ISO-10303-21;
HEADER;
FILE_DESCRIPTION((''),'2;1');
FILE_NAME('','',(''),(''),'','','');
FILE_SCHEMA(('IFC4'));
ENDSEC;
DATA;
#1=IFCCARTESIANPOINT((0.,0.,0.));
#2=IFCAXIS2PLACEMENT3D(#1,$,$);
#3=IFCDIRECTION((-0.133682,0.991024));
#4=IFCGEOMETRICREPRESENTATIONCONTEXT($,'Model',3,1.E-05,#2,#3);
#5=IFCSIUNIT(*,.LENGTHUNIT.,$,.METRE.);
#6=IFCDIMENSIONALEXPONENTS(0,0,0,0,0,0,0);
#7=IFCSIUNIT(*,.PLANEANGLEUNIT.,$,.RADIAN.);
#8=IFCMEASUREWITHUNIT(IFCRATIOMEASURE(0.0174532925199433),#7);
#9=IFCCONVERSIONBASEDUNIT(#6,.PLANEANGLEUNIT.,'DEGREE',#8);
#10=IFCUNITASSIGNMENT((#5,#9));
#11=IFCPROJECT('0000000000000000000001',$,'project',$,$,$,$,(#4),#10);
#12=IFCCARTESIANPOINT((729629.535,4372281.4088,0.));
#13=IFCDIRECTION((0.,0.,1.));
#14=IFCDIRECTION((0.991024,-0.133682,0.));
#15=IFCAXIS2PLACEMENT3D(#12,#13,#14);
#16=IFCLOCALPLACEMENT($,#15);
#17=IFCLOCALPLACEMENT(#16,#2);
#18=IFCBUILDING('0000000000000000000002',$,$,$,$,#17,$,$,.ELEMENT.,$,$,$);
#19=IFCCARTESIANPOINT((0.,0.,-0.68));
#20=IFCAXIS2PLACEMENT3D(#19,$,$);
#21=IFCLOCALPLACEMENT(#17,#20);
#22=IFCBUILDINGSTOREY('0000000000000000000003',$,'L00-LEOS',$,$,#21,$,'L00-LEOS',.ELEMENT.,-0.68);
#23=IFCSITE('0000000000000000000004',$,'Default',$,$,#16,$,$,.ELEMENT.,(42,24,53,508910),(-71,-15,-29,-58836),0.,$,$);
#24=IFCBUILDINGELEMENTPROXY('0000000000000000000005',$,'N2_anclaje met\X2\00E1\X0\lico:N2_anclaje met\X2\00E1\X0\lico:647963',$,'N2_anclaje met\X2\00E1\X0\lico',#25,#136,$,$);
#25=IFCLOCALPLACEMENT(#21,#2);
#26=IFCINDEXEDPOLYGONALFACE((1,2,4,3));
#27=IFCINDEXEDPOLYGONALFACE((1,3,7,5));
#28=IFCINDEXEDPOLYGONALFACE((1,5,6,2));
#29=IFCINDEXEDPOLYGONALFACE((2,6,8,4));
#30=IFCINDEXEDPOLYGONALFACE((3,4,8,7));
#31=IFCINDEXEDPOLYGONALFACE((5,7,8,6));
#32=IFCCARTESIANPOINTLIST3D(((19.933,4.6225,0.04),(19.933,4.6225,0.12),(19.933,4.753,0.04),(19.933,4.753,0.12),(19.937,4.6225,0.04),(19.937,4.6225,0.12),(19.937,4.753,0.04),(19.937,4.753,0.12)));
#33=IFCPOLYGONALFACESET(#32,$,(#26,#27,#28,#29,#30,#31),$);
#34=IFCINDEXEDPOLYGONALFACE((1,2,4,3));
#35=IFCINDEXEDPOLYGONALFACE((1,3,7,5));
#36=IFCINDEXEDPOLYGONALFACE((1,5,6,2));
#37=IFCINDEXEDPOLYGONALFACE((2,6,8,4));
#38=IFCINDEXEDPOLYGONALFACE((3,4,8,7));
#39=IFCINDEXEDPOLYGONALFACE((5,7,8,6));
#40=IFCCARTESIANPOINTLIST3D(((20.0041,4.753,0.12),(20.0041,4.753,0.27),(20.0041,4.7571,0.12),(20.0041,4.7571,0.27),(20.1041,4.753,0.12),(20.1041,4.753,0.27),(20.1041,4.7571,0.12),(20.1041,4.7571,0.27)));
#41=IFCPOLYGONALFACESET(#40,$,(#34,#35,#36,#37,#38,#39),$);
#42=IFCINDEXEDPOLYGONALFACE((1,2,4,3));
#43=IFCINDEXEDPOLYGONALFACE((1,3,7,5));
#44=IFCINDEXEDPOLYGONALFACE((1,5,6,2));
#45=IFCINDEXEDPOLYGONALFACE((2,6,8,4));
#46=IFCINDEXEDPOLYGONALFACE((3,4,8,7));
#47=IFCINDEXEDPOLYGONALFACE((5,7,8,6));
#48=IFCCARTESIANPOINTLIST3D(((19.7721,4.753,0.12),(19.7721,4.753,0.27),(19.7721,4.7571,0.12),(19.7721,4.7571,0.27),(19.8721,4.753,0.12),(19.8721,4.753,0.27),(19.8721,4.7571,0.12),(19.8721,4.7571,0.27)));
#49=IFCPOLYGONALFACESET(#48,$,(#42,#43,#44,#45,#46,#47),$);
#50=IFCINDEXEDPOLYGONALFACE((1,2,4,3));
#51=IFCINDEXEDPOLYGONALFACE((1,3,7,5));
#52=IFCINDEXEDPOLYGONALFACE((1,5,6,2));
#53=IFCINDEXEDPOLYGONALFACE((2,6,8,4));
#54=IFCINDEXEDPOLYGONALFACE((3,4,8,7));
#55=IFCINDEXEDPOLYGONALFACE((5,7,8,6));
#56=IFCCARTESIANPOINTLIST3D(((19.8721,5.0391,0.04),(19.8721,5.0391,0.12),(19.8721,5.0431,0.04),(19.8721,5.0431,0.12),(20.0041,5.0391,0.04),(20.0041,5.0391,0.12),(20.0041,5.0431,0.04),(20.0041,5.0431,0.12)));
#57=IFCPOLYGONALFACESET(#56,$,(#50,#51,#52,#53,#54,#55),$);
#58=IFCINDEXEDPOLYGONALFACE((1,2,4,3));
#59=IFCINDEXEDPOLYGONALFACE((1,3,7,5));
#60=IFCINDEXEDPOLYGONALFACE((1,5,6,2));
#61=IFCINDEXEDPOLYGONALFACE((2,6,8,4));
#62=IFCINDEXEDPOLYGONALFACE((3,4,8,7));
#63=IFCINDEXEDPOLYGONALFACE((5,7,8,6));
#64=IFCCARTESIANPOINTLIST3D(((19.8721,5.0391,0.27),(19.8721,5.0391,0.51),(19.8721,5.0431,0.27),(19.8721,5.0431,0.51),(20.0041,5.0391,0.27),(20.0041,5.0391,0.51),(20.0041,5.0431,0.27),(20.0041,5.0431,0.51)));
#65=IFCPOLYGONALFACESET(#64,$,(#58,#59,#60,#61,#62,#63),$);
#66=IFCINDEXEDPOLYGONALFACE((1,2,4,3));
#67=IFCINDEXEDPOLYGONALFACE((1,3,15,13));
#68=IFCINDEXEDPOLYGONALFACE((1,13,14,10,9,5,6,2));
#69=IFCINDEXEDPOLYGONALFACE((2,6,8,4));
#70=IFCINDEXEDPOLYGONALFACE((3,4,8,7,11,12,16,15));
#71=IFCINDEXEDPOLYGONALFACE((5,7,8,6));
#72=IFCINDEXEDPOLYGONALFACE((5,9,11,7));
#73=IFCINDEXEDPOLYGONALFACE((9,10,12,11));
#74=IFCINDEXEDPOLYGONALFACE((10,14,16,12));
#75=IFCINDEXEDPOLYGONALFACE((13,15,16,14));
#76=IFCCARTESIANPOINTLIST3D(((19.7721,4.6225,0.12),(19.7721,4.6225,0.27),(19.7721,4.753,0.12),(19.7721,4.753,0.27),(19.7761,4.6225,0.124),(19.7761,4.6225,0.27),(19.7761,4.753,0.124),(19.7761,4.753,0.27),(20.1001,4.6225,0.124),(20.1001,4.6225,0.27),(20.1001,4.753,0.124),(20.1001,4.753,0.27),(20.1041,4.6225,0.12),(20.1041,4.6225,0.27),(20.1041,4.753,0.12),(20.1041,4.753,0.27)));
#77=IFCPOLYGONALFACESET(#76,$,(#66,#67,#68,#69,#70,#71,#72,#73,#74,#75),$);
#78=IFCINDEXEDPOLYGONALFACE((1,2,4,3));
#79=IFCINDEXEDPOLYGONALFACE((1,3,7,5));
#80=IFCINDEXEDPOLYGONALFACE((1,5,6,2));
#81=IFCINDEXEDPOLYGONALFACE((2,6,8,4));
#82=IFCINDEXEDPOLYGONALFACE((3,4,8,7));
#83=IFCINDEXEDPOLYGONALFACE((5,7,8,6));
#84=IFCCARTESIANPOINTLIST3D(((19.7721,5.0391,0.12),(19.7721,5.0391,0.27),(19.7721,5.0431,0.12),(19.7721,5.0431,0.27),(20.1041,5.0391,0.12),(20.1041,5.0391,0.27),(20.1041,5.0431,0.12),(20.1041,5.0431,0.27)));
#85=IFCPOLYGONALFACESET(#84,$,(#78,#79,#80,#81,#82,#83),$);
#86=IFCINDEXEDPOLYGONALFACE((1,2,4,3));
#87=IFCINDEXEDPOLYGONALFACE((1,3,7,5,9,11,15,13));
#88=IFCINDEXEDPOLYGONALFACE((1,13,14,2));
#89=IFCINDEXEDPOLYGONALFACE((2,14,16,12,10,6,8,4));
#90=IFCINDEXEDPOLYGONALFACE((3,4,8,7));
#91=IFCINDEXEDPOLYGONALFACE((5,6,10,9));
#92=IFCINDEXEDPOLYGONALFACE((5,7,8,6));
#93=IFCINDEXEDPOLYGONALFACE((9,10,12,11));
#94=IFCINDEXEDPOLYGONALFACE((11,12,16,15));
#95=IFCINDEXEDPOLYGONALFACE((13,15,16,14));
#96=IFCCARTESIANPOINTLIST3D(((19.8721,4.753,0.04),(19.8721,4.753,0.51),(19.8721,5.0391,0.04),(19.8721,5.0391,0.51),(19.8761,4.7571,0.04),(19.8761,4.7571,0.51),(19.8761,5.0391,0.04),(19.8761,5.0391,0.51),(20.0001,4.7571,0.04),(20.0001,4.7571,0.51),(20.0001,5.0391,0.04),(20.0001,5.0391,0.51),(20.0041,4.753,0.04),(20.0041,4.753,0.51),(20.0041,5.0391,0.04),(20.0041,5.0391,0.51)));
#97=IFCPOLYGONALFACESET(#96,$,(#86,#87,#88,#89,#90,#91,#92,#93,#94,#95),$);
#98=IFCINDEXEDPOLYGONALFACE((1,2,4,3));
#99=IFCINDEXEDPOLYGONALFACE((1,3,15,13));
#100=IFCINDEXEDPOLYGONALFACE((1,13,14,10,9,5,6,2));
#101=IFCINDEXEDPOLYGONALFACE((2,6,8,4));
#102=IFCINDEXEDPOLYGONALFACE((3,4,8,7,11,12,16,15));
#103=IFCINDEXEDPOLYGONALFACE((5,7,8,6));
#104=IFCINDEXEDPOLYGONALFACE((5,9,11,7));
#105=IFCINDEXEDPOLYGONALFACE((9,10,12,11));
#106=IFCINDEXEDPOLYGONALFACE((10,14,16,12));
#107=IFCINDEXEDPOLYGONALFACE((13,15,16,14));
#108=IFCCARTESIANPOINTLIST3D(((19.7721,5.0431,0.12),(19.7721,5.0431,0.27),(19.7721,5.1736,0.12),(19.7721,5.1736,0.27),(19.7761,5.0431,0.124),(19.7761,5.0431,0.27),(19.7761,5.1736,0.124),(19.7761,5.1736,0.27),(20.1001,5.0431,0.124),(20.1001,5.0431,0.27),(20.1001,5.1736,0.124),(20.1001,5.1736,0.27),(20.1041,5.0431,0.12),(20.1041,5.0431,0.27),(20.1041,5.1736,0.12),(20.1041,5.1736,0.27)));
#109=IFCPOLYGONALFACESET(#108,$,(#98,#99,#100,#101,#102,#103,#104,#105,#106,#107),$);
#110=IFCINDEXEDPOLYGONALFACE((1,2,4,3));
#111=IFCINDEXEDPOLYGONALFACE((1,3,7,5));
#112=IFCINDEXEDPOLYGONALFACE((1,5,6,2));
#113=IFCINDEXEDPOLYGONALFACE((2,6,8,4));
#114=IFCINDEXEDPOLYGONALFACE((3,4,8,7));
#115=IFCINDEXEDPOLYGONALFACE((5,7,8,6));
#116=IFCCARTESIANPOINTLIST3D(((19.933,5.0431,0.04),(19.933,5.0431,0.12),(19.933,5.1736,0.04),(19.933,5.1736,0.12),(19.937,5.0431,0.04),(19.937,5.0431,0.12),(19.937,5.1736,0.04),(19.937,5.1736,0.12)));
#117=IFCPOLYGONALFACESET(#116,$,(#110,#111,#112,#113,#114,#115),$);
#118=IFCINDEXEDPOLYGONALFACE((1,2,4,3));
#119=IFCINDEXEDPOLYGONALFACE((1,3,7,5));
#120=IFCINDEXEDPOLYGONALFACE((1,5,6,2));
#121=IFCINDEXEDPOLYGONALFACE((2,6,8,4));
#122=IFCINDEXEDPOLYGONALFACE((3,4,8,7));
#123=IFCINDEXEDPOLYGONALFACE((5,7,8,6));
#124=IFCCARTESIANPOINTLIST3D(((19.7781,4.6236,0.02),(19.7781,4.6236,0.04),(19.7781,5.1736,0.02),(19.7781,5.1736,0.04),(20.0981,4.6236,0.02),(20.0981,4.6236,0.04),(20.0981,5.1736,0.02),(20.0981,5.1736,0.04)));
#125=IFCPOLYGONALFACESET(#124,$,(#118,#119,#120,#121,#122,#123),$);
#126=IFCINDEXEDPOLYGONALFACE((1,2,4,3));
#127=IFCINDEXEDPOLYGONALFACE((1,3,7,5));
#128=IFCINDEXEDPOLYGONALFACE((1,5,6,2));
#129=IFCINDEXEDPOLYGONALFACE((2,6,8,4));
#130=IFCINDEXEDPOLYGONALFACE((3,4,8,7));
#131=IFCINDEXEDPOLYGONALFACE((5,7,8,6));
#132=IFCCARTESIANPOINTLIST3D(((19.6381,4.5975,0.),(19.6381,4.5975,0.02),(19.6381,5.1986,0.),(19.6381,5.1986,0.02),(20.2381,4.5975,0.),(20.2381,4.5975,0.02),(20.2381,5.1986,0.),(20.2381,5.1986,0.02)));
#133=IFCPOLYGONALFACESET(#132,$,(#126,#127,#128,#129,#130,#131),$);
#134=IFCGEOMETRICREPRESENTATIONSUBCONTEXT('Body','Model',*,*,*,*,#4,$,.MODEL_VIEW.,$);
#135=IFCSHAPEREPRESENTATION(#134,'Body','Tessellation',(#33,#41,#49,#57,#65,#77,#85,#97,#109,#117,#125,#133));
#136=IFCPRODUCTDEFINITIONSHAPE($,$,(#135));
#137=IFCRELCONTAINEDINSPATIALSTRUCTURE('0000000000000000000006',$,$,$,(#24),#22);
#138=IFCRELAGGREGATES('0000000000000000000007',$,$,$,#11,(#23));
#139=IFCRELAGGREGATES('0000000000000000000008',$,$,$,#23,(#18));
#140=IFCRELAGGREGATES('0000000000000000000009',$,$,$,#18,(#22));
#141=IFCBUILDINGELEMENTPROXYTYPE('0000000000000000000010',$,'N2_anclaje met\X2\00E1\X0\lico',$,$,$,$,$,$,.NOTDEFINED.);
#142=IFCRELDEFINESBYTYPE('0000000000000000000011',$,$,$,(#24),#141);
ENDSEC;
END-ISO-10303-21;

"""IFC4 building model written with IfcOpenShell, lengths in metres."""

from ifc_helpers import new_model, entity, si_unit, converted_unit, direction, frame, frame_2d, origin, origin_2d_with_axis, place, context, subcontext, project, spatial, polyline, rectangle, outline, extrude, source, transform, mapped, type_object, type_shapes, element, save


model = new_model("IFC4")

# Units and contexts
model_context = context("Model", 3, precision=1e-05, world=origin(), true_north=direction((-0.133682, 0.991024)))
body_context = subcontext(model_context, "Body", "Model", "MODEL_VIEW")
ifc_project = project(units=[si_unit("LENGTHUNIT", "METRE"), converted_unit("PLANEANGLEUNIT", "DEGREE", entity("IfcRatioMeasure", 0.0174532925199433), si_unit("PLANEANGLEUNIT", "RADIAN"), dimensions=[0, 0, 0, 0, 0, 0, 0])], contexts=[model_context])

# Site, building, storey
site_placement = place(None, frame((729629.535, 4372281.4088, 0.0), z_axis=(0.0, 0.0, 1.0), x_axis=(0.991024, -0.133682, 0.0)))
site = spatial("IfcSite", under=ifc_project, at=site_placement, Name="Default", CompositionType="ELEMENT", RefLatitude=(42, 24, 53, 508910), RefLongitude=(-71, -15, -29, -58836), RefElevation=0.0)
building_placement = place(site_placement, origin())
building = spatial("IfcBuilding", under=site, at=building_placement, CompositionType="ELEMENT")
storey_placement = place(building_placement, frame((0.0, 0.0, -0.68)))
storey = spatial("IfcBuildingStorey", under=building, at=storey_placement, Name="L00-LEOS", LongName="L00-LEOS", CompositionType="ELEMENT", Elevation=-0.68)

# Building element proxy
building_element_proxy_type_1 = type_object("IfcBuildingElementProxyType", Name="N2_anclaje metálico")
shared_shape_1 = source(origin(), body_context, "Body", "SweptSolid", [
    extrude(rectangle(XDim=0.004, YDim=0.1305, at=origin_2d_with_axis()), frame((0.2103, 0.0, 0.04), z_axis=(0.0, 0.0, 1.0), x_axis=(0.0, -1.0, 0.0)), (0.0, 0.0, 1.0), 0.08),
    extrude(rectangle(XDim=0.1, YDim=0.0042, at=frame_2d((0.0, 0.0), x_axis=(1.0, 0.0))), frame((0.143, 0.1191, 0.12), z_axis=(0.0, 0.0, 1.0), x_axis=(0.0, 1.0, 0.0)), (0.0, 0.0, 1.0), 0.15),
    extrude(rectangle(XDim=0.1, YDim=0.0042, at=origin_2d_with_axis()), frame((0.143, -0.1129, 0.12), z_axis=(0.0, 0.0, 1.0), x_axis=(0.0, 1.0, 0.0)), (0.0, 0.0, 1.0), 0.15),
    extrude(rectangle(XDim=0.132, YDim=0.004, at=frame_2d((0.0, 0.0), x_axis=(1.0, 0.0))), frame((-0.1431, 0.0031, 0.04), z_axis=(0.0, 0.0, 1.0), x_axis=(0.0, 1.0, 0.0)), (0.0, 0.0, 1.0), 0.08),
    extrude(rectangle(XDim=0.132, YDim=0.004, at=frame_2d((0.0, 0.0), x_axis=(1.0, 0.0))), frame((-0.1431, 0.0031, 0.27), z_axis=(0.0, 0.0, 1.0), x_axis=(0.0, 1.0, 0.0)), (0.0, 0.0, 1.0), 0.24),
    extrude(outline(polyline([(-0.076, -0.166), (0.074, -0.166), (0.074, -0.162), (-0.072, -0.162), (-0.072, 0.162), (0.074, 0.162), (0.074, 0.166), (-0.076, 0.166), (-0.076, -0.166)])), frame((0.1451, 0.0031, 0.196), z_axis=(1.0, 0.0, 0.0), x_axis=(0.0, 0.0, 1.0)), (0.0, 0.0, 1.0), 0.1305),
    extrude(rectangle(XDim=0.332, YDim=0.004, at=origin_2d_with_axis()), frame((-0.1431, 0.0031, 0.12), z_axis=(0.0, 0.0, 1.0), x_axis=(0.0, 1.0, 0.0)), (0.0, 0.0, 1.0), 0.15),
    extrude(outline(polyline([(-0.1441, -0.066), (0.142, -0.066), (0.142, -0.062), (-0.14, -0.062), (-0.14, 0.062), (0.142, 0.062), (0.142, 0.066), (-0.1441, 0.066), (-0.1441, -0.066)])), frame((0.001, 0.0031, 0.04), z_axis=(0.0, 0.0, 1.0), x_axis=(-1.0, 0.0, 0.0)), (0.0, 0.0, 1.0), 0.47),
    extrude(outline(polyline([(-0.076, -0.166), (0.074, -0.166), (0.074, -0.162), (-0.072, -0.162), (-0.072, 0.162), (0.074, 0.162), (0.074, 0.166), (-0.076, 0.166), (-0.076, -0.166)])), frame((-0.2756, 0.0031, 0.196), z_axis=(1.0, 0.0, 0.0), x_axis=(0.0, 0.0, 1.0)), (0.0, 0.0, 1.0), 0.1305),
    extrude(rectangle(XDim=0.004, YDim=0.1305, at=origin_2d_with_axis()), frame((-0.2103, 0.0, 0.04), z_axis=(0.0, 0.0, 1.0), x_axis=(0.0, -1.0, 0.0)), (0.0, 0.0, 1.0), 0.08),
    extrude(rectangle(XDim=0.55, YDim=0.32, at=frame_2d((0.0, 0.0), x_axis=(1.0, 0.0))), frame((-0.0006, 0.0031, 0.02), z_axis=(0.0, 0.0, 1.0), x_axis=(-1.0, 0.0, 0.0)), (0.0, 0.0, 1.0), 0.02),
    extrude(rectangle(XDim=0.6012, YDim=0.6, at=frame_2d((0.0, 0.0), x_axis=(1.0, 0.0))), frame((0.0, 0.0031, 0.0), z_axis=(0.0, 0.0, 1.0), x_axis=(-1.0, 0.0, 0.0)), (0.0, 0.0, 1.0), 0.02),
])
type_shapes(building_element_proxy_type_1, [shared_shape_1])
for number, where, z_axis, x_axis, name in (
    (1, (19.935, 4.8981, 0.0), (0.0, 0.0, 1.0), (0.0, -1.0, 0.0), "N2_anclaje metálico:N2_anclaje metálico:647963"),
):
    element("IfcBuildingElementProxy", number, at=place(storey_placement, frame(where, z_axis=z_axis, x_axis=x_axis)), inside=storey, type_object=building_element_proxy_type_1, Name=name, ObjectType="N2_anclaje metálico", context=body_context, shape_type="MappedRepresentation", body=[
        mapped(shared_shape_1, transform((0.0, 0.0, 0.0), scale=1.0)),
    ])

save(model, "model.ifc")
